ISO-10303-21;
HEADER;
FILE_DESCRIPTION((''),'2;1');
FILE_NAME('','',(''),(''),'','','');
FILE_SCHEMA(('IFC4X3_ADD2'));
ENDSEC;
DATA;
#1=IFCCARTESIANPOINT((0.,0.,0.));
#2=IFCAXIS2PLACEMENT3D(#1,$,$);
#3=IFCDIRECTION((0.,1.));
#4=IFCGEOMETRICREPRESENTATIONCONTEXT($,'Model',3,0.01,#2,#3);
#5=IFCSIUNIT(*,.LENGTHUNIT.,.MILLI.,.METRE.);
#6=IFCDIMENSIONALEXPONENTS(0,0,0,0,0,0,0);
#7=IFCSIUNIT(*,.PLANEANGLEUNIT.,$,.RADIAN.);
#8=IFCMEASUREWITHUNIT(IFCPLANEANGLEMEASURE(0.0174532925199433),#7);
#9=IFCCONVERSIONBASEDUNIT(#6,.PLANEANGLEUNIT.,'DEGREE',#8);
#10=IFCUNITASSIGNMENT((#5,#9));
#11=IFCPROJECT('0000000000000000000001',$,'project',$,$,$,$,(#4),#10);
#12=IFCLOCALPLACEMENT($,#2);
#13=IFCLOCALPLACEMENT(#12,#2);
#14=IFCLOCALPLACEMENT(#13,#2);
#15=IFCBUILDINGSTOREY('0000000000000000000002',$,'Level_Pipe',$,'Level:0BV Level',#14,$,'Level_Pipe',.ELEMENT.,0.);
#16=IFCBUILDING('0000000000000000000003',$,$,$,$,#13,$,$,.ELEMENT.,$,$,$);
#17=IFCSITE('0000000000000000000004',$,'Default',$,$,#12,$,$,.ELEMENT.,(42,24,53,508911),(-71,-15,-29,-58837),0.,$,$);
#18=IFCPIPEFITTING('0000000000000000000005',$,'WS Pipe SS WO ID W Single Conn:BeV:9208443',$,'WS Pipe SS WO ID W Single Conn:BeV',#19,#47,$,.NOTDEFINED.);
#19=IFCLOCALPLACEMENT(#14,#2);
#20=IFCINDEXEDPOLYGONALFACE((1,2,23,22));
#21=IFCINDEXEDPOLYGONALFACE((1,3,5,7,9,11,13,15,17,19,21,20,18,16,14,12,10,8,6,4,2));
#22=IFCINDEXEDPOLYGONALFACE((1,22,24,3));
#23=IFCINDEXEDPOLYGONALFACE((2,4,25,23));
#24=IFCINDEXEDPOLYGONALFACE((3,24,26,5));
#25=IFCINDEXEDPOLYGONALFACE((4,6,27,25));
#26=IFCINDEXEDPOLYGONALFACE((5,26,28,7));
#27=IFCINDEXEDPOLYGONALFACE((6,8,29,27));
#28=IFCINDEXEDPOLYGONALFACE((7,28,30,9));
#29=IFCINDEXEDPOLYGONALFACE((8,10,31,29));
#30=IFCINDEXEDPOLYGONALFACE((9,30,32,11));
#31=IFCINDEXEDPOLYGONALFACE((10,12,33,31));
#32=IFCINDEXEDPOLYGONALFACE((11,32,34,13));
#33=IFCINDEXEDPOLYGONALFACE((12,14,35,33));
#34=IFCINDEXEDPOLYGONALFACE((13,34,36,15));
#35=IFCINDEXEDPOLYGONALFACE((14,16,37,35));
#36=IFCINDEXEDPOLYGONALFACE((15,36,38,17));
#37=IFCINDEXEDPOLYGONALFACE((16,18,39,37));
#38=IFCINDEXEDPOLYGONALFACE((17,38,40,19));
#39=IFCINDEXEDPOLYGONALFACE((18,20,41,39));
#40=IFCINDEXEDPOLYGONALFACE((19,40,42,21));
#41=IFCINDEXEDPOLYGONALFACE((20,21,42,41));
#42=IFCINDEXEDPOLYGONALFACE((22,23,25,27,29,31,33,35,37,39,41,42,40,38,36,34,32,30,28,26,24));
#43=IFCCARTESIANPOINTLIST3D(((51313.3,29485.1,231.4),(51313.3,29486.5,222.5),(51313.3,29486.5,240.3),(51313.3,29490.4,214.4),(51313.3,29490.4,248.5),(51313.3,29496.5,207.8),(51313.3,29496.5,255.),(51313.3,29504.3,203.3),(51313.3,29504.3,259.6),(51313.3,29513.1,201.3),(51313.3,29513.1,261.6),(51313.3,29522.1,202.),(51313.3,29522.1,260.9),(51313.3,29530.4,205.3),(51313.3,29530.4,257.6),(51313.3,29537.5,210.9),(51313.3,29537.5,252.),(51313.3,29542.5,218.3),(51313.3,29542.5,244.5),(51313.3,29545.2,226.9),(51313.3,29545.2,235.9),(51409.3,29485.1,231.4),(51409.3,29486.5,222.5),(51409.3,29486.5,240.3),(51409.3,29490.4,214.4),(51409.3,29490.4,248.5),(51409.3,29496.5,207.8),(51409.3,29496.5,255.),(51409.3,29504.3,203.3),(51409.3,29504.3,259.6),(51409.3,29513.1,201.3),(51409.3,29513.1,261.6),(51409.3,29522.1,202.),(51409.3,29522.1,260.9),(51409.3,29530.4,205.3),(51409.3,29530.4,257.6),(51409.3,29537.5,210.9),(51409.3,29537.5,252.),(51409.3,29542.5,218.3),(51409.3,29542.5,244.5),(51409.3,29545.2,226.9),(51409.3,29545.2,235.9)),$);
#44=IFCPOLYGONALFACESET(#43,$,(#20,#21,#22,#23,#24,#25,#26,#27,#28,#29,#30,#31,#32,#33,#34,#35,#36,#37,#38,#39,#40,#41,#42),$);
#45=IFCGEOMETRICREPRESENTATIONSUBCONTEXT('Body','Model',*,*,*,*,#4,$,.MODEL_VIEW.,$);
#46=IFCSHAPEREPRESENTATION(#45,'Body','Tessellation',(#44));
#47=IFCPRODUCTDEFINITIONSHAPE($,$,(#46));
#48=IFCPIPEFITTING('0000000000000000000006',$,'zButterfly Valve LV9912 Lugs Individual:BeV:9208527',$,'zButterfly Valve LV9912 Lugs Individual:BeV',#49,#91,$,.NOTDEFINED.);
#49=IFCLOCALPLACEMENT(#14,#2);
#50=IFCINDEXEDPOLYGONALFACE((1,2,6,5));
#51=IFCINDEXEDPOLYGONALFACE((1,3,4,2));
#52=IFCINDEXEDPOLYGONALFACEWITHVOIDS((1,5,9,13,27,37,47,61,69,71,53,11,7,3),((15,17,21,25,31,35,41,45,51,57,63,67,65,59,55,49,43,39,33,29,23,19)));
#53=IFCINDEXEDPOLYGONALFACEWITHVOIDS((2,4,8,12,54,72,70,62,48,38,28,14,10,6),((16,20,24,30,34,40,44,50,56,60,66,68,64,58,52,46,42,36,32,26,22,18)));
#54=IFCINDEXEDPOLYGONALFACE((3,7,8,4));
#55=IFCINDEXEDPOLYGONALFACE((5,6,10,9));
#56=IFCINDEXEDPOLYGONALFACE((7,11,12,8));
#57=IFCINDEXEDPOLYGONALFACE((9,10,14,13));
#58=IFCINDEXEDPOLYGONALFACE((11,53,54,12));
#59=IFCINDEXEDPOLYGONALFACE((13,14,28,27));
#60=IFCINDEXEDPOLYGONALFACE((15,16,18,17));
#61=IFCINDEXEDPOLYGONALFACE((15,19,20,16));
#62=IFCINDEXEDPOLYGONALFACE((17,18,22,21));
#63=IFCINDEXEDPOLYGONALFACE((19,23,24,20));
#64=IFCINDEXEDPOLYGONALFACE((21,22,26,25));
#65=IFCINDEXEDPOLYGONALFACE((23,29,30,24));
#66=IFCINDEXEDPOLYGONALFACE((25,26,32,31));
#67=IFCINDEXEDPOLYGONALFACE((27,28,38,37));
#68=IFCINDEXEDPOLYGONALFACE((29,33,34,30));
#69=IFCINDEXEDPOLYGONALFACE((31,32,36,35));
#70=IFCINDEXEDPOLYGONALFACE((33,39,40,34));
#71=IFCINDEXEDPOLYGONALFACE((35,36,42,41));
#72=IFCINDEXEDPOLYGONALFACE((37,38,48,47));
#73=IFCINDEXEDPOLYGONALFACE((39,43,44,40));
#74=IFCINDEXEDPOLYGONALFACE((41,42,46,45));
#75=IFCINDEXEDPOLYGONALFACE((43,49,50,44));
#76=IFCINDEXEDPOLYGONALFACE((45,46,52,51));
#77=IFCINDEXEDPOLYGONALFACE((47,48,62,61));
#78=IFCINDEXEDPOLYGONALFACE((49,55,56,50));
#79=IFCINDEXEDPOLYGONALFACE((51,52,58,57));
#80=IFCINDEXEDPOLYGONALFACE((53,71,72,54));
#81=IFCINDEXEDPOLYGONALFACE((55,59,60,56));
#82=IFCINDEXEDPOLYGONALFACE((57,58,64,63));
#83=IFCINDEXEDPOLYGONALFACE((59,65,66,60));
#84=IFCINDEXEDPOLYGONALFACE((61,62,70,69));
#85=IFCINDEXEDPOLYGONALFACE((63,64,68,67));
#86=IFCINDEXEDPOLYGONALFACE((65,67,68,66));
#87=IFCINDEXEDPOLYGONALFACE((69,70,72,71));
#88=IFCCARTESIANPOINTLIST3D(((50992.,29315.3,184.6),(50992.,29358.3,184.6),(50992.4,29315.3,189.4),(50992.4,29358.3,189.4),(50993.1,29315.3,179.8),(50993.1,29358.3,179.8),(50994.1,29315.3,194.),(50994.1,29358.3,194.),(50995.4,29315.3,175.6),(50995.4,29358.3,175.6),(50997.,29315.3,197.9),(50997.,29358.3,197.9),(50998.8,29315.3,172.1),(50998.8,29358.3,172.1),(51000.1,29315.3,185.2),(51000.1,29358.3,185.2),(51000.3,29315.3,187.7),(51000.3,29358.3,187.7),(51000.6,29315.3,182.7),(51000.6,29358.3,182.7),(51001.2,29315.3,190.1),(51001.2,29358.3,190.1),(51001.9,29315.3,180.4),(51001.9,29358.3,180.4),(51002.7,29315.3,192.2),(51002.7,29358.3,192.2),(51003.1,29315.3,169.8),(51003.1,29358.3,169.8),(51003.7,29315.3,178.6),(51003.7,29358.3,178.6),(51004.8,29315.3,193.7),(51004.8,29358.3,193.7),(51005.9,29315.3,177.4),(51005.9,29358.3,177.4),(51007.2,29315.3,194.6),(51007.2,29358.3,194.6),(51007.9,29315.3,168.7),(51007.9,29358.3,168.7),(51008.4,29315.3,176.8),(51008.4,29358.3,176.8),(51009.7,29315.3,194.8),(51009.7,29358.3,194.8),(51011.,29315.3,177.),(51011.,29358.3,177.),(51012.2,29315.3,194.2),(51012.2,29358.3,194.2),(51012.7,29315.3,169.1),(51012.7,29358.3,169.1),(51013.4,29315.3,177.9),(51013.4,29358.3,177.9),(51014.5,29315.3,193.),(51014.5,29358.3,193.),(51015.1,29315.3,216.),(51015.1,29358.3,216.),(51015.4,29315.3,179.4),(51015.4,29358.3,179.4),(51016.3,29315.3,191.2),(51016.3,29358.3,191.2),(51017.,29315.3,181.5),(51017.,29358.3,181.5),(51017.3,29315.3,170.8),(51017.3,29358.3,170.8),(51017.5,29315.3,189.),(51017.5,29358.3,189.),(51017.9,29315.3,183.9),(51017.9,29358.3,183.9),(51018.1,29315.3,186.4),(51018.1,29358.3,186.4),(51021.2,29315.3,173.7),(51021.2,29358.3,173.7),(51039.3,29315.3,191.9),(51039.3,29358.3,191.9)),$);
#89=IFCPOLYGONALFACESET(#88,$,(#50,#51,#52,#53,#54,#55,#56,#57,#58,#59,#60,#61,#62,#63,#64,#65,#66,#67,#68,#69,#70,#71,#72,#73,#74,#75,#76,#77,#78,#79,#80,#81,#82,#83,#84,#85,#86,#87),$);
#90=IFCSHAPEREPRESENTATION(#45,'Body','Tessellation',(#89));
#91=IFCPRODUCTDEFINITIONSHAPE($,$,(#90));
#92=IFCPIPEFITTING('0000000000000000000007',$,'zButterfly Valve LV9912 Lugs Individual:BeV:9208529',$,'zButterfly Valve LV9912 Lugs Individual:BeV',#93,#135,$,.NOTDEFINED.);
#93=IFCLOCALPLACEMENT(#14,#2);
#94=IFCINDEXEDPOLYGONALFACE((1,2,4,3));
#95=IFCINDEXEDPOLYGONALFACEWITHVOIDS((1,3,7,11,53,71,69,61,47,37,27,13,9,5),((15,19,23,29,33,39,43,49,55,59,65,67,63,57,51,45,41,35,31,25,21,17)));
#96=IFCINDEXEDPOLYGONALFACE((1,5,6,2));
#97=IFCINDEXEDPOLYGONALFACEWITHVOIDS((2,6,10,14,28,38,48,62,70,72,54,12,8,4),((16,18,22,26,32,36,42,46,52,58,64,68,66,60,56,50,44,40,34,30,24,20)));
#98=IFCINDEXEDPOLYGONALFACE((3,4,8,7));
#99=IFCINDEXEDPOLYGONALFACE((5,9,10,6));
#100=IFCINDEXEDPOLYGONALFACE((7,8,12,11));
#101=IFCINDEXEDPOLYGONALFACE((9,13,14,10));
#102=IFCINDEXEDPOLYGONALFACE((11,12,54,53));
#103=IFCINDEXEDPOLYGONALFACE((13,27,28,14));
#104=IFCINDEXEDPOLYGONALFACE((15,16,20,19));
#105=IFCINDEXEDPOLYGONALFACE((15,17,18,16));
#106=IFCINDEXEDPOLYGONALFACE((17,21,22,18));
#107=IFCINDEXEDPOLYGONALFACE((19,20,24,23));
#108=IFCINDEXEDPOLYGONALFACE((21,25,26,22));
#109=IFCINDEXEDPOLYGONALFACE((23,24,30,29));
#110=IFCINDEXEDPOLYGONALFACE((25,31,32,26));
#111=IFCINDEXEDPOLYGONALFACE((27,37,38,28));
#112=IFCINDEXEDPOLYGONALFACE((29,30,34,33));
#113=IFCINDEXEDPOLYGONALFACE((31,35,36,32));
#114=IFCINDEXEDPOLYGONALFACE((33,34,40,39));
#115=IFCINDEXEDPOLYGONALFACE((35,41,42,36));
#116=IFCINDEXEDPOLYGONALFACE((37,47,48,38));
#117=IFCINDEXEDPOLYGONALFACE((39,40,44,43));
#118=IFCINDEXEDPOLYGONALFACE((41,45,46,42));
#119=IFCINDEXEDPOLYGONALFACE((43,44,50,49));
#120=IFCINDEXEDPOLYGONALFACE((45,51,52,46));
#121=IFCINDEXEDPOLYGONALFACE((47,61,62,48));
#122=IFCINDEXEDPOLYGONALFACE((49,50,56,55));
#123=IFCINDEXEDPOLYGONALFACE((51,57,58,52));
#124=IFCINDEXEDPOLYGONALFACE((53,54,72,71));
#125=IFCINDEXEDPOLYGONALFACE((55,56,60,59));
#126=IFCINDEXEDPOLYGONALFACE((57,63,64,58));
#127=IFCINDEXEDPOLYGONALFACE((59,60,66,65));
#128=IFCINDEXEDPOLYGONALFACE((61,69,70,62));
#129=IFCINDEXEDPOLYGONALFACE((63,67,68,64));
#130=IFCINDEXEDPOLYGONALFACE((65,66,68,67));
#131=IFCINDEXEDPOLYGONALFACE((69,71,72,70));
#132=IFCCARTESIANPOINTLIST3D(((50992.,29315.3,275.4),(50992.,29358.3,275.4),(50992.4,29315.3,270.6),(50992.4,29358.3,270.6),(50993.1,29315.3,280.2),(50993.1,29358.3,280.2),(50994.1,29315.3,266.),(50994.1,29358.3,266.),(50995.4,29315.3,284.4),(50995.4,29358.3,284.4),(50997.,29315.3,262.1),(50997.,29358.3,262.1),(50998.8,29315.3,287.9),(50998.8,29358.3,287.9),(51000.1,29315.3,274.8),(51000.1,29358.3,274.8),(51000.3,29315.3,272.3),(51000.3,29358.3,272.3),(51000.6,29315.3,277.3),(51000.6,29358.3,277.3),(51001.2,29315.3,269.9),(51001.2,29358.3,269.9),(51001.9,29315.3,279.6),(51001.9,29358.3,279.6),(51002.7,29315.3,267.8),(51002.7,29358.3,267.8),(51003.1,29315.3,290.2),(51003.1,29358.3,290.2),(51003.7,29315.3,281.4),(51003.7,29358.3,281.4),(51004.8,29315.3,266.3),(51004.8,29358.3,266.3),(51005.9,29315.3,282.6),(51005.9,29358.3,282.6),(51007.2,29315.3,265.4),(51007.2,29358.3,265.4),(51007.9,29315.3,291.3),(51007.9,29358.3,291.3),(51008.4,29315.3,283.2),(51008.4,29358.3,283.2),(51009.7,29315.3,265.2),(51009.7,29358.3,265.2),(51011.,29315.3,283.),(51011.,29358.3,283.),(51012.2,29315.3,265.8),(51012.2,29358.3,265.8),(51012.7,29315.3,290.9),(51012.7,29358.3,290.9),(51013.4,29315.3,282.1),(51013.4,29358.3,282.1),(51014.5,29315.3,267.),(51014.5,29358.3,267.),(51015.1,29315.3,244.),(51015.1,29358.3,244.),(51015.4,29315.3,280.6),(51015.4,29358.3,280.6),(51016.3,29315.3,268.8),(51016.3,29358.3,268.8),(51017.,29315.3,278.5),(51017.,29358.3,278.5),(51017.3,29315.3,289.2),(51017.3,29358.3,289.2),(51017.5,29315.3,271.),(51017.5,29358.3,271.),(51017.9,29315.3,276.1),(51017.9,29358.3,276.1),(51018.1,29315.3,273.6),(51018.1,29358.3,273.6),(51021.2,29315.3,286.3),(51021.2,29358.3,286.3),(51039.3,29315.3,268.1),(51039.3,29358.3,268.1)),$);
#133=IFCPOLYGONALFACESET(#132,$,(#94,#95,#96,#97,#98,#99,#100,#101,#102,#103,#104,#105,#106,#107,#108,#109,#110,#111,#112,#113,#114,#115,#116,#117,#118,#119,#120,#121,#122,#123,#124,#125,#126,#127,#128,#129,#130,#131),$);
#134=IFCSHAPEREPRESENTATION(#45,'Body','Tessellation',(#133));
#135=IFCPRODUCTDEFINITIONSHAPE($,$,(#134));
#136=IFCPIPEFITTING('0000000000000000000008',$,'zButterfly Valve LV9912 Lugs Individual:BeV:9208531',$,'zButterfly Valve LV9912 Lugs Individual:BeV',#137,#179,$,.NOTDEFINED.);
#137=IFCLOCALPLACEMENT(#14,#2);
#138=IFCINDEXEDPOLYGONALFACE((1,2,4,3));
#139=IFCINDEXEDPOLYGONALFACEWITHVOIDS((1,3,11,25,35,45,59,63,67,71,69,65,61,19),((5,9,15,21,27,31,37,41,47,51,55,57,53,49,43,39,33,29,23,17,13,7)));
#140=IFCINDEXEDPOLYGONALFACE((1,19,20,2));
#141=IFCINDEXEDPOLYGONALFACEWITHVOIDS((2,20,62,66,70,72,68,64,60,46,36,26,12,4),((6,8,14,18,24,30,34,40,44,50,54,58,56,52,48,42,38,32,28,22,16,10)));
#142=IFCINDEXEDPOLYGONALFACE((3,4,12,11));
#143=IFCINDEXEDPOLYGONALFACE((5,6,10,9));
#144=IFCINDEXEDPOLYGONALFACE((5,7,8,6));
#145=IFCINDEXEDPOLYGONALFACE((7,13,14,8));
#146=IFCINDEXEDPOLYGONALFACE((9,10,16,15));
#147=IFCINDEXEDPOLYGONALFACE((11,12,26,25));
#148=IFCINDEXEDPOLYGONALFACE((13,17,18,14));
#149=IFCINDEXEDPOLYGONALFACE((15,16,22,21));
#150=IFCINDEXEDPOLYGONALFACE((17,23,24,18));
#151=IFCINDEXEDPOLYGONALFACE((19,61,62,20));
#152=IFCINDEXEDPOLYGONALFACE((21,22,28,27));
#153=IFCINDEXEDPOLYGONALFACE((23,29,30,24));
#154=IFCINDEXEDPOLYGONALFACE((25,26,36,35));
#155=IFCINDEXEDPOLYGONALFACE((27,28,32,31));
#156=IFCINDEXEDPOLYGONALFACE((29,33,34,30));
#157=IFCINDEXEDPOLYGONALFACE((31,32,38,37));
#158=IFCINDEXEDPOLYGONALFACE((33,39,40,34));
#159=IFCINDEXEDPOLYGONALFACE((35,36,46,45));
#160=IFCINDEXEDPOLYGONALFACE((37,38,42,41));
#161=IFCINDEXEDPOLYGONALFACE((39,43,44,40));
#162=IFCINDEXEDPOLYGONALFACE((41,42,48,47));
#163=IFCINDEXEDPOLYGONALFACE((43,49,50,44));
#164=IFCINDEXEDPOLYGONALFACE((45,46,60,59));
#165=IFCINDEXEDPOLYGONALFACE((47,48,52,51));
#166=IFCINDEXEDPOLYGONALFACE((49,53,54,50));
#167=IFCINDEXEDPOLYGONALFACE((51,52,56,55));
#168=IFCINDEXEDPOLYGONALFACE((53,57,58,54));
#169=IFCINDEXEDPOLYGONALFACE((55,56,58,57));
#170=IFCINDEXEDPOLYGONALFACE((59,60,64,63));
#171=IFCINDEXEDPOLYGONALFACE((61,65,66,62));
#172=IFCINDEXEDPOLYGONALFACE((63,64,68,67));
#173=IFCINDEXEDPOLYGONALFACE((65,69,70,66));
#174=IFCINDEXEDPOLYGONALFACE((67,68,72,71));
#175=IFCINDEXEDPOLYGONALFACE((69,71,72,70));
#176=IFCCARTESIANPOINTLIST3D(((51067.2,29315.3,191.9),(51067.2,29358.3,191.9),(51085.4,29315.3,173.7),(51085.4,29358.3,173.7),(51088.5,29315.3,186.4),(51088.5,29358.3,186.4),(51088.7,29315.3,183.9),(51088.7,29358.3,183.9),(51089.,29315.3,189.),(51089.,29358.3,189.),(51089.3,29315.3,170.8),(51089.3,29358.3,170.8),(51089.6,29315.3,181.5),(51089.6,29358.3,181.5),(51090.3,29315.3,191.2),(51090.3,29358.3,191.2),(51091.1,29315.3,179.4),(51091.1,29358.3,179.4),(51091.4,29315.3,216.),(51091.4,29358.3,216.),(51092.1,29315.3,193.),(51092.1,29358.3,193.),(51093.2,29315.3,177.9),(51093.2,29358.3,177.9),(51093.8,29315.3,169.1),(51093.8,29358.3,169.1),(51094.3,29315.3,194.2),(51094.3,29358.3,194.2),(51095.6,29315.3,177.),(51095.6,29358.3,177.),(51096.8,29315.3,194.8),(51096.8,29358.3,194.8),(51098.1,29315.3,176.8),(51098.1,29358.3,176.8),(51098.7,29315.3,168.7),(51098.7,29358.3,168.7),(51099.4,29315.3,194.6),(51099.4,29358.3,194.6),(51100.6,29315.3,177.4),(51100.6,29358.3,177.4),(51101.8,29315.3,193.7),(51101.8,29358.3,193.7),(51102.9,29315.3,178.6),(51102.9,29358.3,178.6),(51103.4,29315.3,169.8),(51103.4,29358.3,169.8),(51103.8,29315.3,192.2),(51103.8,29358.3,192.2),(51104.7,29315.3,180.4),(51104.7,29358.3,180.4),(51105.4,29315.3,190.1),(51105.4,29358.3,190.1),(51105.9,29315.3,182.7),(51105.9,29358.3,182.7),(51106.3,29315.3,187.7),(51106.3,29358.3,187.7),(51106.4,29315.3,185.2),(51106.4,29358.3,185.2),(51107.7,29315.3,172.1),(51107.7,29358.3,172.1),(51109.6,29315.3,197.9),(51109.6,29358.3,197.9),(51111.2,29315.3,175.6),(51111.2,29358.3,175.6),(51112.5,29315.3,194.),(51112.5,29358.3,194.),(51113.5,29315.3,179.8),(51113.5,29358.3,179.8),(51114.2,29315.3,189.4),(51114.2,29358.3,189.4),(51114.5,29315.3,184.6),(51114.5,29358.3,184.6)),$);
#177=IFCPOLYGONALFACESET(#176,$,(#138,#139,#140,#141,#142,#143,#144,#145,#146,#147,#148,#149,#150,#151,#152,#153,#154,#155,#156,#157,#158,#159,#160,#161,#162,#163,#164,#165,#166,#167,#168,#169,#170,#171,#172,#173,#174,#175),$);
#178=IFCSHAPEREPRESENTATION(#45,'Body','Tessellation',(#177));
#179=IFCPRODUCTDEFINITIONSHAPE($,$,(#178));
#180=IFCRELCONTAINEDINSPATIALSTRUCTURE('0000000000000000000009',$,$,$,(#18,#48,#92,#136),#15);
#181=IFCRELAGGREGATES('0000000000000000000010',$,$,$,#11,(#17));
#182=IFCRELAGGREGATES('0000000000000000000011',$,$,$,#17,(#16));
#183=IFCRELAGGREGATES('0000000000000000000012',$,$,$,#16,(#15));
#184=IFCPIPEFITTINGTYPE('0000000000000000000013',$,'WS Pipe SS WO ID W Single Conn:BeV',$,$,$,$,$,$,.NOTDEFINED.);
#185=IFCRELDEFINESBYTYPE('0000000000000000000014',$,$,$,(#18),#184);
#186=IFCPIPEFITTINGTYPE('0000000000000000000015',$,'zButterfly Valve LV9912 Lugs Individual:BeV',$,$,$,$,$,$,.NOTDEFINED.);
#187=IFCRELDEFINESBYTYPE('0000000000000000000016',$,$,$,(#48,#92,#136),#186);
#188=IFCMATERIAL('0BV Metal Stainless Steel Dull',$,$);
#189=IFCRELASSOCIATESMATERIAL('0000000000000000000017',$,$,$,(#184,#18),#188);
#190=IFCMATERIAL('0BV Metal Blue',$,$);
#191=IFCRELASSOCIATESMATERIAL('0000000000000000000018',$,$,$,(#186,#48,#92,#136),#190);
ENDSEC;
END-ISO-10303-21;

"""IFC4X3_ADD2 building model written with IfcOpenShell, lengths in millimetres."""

from ifc_helpers import new_model, entity, si_unit, converted_unit, direction, frame, frame_2d, origin, place, context, subcontext, project, spatial, polyline, circle_curve, parameter, trimmed, segment, composite_curve, circle, outline, extrude, source, transform, mapped, material, type_object, type_shapes, element, save


model = new_model("IFC4X3_ADD2")

# Units and contexts
model_context = context("Model", 3, precision=0.01, world=origin(), true_north=direction((0.0, 1.0)))
body_context = subcontext(model_context, "Body", "Model", "MODEL_VIEW")
ifc_project = project(units=[si_unit("LENGTHUNIT", "METRE", prefix="MILLI"), converted_unit("PLANEANGLEUNIT", "DEGREE", entity("IfcPlaneAngleMeasure", 0.0174532925199433), si_unit("PLANEANGLEUNIT", "RADIAN"), dimensions=[0, 0, 0, 0, 0, 0, 0])], contexts=[model_context])

# Site, building, storey
site_placement = place(None, origin())
site = spatial("IfcSite", under=ifc_project, at=site_placement, Name="Default", CompositionType="ELEMENT", RefLatitude=(42, 24, 53, 508911), RefLongitude=(-71, -15, -29, -58837), RefElevation=0.0)
building_placement = place(site_placement, origin())
building = spatial("IfcBuilding", under=site, at=building_placement, CompositionType="ELEMENT")
storey_placement = place(building_placement, origin())
storey = spatial("IfcBuildingStorey", under=building, at=storey_placement, Name="Level_Pipe", ObjectType="Level:0BV Level", LongName="Level_Pipe", CompositionType="ELEMENT", Elevation=0.0)

# Pipe fittings
ifc_material_1 = material(Name="0BV Metal Stainless Steel Dull")
pipe_fitting_type_1 = type_object("IfcPipeFittingType", Name="WS Pipe SS WO ID W Single Conn:BeV", PredefinedType="NOTDEFINED", material=ifc_material_1)
shared_shape_1 = source(origin(), body_context, "Body", "SweptSolid", [
    extrude(circle(Radius=30.2, at=frame_2d((0.0, 0.0), x_axis=(1.0, 0.0))), frame((-48.0, 0.0, 0.0), z_axis=(1.0, 0.0, 0.0), x_axis=(0.0, -1.0, 0.0)), (0.0, 0.0, 1.0), 96.0),
])
type_shapes(pipe_fitting_type_1, [shared_shape_1])
pipe_fitting_1_placement = place(storey_placement, frame((51361.3, 29515.3, 231.4)))
element("IfcPipeFitting", 1, at=pipe_fitting_1_placement, inside=storey, type_object=pipe_fitting_type_1, material=ifc_material_1, Name="WS Pipe SS WO ID W Single Conn:BeV:9208443", ObjectType="WS Pipe SS WO ID W Single Conn:BeV", PredefinedType="NOTDEFINED", context=body_context, shape_type="MappedRepresentation", body=[
    mapped(shared_shape_1, transform((0.0, 0.0, 0.0), scale=1.0)),
])
ifc_material_2 = material(Name="0BV Metal Blue")
pipe_fitting_type_2 = type_object("IfcPipeFittingType", Name="zButterfly Valve LV9912 Lugs Individual:BeV", PredefinedType="NOTDEFINED", material=ifc_material_2)
shared_shape_2 = source(origin(), body_context, "Body", "SweptSolid", [
    extrude(outline(composite_curve([segment(polyline([(-17.1, -12.8), (17.1, -12.8)]), True, "CONTINUOUS"), segment(polyline([(17.1, -12.8), (17.1, 12.8)]), True, "CONTINUOUS"), segment(trimmed(circle_curve(frame_2d((0.0, 12.8), x_axis=(1.0, 0.0)), 17.1), [parameter(360.0)], [parameter(180.0)], True, "PARAMETER"), True, "CONTINUOUS"), segment(polyline([(-17.1, 12.8), (-17.1, -12.8)]), True, "CONTINUOUS")], self_intersect=False), holes=[composite_curve([segment(trimmed(circle_curve(frame_2d((0.0, 12.8), x_axis=(1.0, 0.0)), 9.0), [parameter(0.0)], [parameter(180.0)], True, "PARAMETER"), False, "CONTINUOUS"), segment(trimmed(circle_curve(frame_2d((0.0, 12.8), x_axis=(1.0, 0.0)), 9.0), [parameter(180.0)], [parameter(0.0)], True, "PARAMETER"), False, "CONTINUOUS")], self_intersect=False)]), frame((0.0, -12.8, -21.5)), (0.0, 0.0, 1.0), 43.0),
])
type_shapes(pipe_fitting_type_2, [shared_shape_2])
for number, where, z_axis, x_axis, name in (
    (2, (51009.1, 29336.8, 185.8), (0.0, 1.0, 0.0), (0.707107, 0.0, -0.707107), "zButterfly Valve LV9912 Lugs Individual:BeV:9208527"),
    (3, (51009.1, 29336.8, 274.2), (0.0, 1.0, 0.0), (-0.707107, 0.0, -0.707107), "zButterfly Valve LV9912 Lugs Individual:BeV:9208529"),
    (4, (51097.5, 29336.8, 185.8), (0.0, 1.0, 0.0), (0.707107, 0.0, 0.707107), "zButterfly Valve LV9912 Lugs Individual:BeV:9208531"),
):
    element("IfcPipeFitting", number, at=place(storey_placement, frame(where, z_axis=z_axis, x_axis=x_axis)), inside=storey, type_object=pipe_fitting_type_2, material=ifc_material_2, Name=name, ObjectType="zButterfly Valve LV9912 Lugs Individual:BeV", PredefinedType="NOTDEFINED", context=body_context, shape_type="MappedRepresentation", body=[
        mapped(shared_shape_2, transform((0.0, 0.0, 0.0), scale=1.0)),
    ])

save(model, "model.ifc")
